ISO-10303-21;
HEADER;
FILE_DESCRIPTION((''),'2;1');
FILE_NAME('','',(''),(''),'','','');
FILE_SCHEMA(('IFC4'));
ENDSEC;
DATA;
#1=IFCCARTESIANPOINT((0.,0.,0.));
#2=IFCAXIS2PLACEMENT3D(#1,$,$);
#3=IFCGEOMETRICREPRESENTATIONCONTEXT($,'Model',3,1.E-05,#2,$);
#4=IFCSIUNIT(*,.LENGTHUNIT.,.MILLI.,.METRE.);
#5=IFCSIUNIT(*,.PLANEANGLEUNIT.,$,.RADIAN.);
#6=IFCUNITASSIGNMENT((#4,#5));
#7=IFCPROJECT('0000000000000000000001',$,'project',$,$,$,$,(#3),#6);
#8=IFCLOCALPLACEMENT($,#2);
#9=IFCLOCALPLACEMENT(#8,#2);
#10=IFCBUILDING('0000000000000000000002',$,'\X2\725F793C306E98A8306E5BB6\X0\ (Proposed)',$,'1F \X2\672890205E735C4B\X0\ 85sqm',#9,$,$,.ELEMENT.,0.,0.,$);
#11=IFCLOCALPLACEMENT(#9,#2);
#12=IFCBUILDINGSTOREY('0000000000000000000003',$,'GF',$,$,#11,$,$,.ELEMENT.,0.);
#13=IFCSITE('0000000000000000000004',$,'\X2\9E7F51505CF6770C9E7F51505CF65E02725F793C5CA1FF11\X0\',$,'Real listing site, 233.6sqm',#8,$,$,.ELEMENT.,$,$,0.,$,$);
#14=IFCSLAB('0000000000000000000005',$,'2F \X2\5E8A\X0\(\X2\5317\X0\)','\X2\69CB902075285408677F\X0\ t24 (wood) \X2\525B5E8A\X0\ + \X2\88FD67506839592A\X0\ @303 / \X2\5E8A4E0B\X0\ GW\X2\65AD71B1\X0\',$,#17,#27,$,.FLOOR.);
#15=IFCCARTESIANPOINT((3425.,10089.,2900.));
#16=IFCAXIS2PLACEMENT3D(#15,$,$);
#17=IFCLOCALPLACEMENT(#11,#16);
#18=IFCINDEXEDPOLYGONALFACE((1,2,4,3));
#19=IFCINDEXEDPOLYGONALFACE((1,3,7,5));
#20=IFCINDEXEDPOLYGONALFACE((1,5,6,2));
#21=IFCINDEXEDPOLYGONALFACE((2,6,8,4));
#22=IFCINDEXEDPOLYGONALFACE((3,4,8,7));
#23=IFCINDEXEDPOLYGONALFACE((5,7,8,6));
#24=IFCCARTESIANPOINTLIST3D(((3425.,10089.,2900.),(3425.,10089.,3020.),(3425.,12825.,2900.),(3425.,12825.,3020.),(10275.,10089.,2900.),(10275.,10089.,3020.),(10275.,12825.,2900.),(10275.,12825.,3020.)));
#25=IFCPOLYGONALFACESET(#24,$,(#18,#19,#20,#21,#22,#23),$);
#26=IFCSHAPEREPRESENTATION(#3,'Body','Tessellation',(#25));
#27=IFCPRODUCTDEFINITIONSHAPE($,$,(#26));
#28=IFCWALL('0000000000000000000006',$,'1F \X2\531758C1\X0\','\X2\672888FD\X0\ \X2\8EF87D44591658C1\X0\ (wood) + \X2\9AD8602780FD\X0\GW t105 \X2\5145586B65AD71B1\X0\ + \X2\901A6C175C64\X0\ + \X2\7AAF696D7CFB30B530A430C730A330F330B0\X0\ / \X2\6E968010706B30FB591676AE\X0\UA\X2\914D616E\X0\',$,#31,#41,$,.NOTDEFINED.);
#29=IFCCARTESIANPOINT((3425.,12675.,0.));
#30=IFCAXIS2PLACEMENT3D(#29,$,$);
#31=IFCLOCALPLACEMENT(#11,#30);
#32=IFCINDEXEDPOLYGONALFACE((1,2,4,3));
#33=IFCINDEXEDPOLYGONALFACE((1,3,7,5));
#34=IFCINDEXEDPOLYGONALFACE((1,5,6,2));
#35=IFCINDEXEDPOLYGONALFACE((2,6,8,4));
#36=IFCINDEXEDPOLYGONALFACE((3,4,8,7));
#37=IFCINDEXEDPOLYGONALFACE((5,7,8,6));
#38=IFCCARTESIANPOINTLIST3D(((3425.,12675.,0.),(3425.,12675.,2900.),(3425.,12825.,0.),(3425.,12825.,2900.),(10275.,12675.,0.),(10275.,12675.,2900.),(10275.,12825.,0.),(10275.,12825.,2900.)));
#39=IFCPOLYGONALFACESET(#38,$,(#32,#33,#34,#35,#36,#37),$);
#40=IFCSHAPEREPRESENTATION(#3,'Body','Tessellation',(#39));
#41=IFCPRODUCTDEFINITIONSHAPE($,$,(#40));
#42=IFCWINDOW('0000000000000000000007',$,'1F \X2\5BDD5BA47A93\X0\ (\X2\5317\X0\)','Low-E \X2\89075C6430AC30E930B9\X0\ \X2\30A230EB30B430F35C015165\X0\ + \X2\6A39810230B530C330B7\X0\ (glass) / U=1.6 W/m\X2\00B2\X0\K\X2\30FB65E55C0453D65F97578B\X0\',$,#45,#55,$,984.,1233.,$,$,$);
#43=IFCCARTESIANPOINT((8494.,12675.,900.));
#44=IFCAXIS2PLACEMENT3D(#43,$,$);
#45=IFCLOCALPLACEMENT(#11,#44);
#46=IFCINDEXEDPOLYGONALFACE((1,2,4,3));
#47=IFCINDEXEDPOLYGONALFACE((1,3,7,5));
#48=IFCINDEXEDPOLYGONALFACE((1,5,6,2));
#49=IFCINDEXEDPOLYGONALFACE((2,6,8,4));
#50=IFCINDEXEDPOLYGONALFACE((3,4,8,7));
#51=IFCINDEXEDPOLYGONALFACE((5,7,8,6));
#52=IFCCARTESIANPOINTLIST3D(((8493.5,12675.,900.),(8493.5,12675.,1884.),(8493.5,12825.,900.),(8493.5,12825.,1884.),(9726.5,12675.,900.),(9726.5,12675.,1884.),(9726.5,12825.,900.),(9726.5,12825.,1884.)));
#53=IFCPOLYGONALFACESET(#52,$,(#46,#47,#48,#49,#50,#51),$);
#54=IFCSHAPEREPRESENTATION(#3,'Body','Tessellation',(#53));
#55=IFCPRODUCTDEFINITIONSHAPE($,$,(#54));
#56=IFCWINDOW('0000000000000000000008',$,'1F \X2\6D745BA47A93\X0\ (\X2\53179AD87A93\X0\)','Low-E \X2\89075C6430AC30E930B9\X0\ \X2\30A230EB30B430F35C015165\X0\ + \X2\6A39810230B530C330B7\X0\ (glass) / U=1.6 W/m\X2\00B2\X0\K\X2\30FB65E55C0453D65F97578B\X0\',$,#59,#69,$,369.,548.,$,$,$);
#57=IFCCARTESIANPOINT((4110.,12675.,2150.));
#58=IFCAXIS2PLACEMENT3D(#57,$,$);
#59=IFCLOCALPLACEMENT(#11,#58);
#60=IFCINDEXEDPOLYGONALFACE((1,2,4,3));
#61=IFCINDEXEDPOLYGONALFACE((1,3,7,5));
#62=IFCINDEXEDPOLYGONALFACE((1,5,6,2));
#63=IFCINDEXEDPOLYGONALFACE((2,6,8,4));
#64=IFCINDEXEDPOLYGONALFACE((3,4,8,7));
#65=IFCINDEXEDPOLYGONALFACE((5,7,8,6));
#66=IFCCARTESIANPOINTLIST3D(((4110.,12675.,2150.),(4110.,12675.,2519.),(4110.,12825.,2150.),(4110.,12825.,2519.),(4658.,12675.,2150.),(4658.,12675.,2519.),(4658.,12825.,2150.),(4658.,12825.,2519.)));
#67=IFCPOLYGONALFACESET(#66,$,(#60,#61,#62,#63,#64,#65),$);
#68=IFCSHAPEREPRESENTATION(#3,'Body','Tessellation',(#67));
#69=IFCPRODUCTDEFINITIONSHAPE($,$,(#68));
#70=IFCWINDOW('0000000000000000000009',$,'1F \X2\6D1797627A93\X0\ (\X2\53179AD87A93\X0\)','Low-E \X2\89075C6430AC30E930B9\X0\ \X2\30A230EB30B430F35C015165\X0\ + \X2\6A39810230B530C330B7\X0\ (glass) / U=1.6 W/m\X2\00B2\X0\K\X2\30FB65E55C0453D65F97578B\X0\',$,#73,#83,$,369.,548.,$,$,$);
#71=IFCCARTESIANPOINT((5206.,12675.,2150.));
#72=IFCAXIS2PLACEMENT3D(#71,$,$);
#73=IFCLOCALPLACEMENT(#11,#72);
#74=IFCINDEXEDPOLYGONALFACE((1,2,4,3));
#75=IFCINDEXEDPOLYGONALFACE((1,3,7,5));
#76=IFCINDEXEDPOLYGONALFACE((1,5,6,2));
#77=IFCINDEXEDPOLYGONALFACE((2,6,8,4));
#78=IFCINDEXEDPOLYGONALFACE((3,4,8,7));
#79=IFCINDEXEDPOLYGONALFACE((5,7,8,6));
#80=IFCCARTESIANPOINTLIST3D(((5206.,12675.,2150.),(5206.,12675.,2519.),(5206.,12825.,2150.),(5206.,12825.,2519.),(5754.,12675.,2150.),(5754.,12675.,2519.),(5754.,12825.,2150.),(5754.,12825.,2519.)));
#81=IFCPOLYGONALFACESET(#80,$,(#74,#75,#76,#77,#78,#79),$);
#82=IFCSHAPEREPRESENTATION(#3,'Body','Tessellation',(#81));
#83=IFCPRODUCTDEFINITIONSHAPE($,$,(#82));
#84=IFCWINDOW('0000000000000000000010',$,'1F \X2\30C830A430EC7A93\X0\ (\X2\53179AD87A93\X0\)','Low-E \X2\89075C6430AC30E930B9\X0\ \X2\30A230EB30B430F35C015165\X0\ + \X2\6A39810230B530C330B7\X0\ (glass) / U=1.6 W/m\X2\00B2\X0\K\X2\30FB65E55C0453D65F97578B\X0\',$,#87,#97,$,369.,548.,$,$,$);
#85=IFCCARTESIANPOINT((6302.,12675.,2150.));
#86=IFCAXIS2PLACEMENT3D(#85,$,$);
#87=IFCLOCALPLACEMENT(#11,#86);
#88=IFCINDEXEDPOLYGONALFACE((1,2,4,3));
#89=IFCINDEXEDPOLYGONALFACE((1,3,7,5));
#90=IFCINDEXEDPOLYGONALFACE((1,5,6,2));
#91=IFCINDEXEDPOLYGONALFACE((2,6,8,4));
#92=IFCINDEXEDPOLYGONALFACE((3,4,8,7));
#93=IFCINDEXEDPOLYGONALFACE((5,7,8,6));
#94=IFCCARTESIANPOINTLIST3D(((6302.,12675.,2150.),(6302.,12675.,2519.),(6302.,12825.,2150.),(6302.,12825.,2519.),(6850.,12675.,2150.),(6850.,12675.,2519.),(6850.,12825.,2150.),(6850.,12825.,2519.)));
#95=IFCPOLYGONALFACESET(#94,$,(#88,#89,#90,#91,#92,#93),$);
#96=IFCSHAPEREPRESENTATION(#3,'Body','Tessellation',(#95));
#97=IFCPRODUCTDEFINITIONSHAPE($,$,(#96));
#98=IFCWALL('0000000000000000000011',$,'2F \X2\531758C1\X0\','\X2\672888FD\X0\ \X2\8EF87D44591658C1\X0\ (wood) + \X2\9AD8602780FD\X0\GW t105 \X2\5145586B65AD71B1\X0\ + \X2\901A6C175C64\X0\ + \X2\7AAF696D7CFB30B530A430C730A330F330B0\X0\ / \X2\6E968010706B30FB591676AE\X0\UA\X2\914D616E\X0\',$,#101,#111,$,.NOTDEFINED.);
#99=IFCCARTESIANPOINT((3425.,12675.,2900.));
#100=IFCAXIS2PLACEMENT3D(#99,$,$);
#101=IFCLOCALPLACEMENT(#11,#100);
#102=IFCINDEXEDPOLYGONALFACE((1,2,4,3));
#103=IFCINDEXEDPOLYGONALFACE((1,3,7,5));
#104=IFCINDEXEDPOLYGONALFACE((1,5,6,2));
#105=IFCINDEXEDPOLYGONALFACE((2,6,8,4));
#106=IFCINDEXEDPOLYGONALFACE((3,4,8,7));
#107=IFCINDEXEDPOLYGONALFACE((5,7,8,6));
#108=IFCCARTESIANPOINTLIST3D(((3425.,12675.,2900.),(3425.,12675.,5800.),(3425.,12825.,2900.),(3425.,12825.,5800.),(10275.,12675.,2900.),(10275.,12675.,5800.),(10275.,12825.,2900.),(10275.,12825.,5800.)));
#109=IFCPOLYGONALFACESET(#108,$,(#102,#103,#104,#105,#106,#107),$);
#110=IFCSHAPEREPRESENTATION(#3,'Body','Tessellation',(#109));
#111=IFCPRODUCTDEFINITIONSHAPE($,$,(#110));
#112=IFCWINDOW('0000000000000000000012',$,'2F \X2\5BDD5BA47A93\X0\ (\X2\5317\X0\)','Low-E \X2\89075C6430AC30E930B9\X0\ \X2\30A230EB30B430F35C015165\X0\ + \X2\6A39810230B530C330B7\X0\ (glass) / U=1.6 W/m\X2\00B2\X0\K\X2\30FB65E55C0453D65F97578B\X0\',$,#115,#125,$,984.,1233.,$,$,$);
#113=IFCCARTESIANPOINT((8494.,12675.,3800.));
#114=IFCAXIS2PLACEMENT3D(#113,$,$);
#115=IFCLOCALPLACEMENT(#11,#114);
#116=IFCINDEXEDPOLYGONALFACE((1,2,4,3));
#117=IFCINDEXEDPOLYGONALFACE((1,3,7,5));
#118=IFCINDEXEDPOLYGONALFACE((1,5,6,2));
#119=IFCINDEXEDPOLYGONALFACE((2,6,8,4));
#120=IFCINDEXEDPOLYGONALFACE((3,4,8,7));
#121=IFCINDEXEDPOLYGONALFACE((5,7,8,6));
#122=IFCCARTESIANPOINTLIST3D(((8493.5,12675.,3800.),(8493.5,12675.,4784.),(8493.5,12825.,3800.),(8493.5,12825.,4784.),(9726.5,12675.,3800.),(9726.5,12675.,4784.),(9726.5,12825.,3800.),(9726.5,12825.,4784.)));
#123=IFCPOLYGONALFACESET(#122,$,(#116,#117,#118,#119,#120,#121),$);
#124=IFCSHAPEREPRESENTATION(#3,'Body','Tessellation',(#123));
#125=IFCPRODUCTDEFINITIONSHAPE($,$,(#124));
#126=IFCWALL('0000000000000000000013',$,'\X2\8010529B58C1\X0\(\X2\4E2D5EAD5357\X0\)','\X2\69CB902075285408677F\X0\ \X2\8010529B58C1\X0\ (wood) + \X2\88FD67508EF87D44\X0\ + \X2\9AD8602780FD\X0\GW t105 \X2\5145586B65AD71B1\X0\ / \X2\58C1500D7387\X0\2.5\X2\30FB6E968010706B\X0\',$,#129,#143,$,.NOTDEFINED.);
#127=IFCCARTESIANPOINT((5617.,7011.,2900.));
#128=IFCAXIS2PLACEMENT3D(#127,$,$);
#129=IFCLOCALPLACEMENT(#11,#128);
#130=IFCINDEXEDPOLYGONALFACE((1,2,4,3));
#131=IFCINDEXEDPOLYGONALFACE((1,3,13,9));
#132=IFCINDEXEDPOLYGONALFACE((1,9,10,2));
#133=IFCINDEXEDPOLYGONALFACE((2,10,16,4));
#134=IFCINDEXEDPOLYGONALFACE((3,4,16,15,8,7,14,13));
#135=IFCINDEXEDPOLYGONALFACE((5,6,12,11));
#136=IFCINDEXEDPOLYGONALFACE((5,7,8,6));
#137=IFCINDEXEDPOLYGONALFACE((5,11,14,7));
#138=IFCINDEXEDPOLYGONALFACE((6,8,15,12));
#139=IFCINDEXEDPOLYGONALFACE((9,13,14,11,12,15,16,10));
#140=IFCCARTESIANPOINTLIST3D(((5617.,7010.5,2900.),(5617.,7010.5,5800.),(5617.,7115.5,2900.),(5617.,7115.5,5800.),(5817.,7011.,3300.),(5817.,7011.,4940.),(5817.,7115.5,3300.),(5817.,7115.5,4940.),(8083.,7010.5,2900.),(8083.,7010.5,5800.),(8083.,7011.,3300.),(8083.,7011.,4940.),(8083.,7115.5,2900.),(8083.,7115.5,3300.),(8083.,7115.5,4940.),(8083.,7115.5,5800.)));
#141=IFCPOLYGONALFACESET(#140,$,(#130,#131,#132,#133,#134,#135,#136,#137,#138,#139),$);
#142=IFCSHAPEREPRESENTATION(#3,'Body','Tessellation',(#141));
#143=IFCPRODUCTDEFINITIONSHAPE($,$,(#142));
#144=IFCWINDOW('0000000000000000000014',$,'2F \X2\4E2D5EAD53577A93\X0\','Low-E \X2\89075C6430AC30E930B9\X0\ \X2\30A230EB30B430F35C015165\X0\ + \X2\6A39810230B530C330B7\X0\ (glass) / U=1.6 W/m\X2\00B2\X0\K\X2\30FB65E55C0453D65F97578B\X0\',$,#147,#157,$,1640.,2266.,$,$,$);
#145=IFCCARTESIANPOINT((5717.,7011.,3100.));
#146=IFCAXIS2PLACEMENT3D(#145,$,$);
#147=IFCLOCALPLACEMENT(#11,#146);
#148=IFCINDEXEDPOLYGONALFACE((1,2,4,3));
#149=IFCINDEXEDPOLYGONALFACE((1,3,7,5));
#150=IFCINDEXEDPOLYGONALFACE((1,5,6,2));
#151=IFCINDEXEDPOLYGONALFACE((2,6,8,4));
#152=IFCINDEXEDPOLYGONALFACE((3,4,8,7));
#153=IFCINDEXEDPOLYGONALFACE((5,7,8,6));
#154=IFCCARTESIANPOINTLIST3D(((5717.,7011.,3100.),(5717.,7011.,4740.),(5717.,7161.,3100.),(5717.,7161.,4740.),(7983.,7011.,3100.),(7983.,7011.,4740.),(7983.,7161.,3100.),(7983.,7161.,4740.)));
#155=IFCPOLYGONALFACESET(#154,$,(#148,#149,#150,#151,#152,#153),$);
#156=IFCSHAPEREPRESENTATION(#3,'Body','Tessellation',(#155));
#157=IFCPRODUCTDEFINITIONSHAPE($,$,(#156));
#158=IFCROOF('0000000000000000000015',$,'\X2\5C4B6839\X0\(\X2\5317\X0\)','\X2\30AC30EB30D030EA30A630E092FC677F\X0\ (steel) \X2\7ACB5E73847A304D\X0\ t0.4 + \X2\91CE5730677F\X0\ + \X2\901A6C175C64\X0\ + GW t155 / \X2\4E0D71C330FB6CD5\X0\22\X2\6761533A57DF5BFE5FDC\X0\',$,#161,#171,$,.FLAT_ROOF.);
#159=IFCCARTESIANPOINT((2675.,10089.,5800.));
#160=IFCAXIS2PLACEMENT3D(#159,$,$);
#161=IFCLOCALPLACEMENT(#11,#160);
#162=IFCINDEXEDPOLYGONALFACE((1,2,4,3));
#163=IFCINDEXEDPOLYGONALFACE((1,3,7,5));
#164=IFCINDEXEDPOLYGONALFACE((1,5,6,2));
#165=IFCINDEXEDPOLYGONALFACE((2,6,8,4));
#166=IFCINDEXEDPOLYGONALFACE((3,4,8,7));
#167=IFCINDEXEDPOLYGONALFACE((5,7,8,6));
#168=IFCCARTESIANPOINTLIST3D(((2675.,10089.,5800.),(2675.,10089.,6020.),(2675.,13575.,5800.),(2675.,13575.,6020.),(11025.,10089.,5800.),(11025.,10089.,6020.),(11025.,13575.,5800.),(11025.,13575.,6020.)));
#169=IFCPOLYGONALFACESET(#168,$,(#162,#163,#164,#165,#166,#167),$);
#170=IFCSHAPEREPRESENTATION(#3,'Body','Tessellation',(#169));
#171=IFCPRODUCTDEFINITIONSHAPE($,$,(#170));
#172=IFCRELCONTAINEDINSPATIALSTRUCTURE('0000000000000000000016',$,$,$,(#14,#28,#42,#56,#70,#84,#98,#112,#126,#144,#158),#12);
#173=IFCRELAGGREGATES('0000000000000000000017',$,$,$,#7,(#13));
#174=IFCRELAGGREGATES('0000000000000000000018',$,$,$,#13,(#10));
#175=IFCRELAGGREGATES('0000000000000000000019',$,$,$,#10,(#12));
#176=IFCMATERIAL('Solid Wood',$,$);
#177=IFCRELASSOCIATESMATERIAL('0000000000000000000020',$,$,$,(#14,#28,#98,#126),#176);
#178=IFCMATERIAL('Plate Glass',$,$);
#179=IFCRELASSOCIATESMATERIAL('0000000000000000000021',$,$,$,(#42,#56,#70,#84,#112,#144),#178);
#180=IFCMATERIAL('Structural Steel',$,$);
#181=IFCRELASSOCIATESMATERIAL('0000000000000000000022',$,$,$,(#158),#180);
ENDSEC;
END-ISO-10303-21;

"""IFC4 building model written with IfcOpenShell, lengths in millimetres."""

from ifc_helpers import new_model, si_unit, frame, frame_2d, origin, place, context, project, spatial, rectangle, extrude, material, element, fill, save


model = new_model("IFC4")

# Units and contexts
model_context = context("Model", 3, precision=1e-05, world=origin())
ifc_project = project(units=[si_unit("LENGTHUNIT", "METRE", prefix="MILLI"), si_unit("PLANEANGLEUNIT", "RADIAN")], contexts=[model_context])

# Site, building, storey
site_placement = place(None, origin())
site = spatial("IfcSite", under=ifc_project, at=site_placement, Name="鹿児島県鹿児島市牟礼岡１", ObjectType="Real listing site, 233.6sqm", CompositionType="ELEMENT", RefElevation=0.0)
building_placement = place(site_placement, origin())
building = spatial("IfcBuilding", under=site, at=building_placement, Name="牟礼の風の家 (Proposed)", ObjectType="1F 木造平屋 85sqm", CompositionType="ELEMENT", ElevationOfRefHeight=0.0, ElevationOfTerrain=0.0)
storey_placement = place(building_placement, origin())
storey = spatial("IfcBuildingStorey", under=building, at=storey_placement, Name="GF", CompositionType="ELEMENT", Elevation=0.0)

# Slab
ifc_material_1 = material(Name="Solid Wood")
slab_1_placement = place(storey_placement, frame((3425.0, 10089.0, 2900.0)))
element("IfcSlab", 1, at=slab_1_placement, inside=storey, material=ifc_material_1, Name="2F 床(北)", Description="構造用合板 t24 (wood) 剛床 + 製材根太 @303 / 床下 GW断熱", PredefinedType="FLOOR", context=model_context, shape_type="SweptSolid", body=[
    extrude(rectangle(XDim=6850.0, YDim=2736.0, at=frame_2d((3425.0, 1368.0))), frame((3425.0, 10089.0, 2900.0)), (0.0, 0.0, 1.0), 120.0),
])

# Wall, openings, windows
wall_1_placement = place(storey_placement, frame((3425.0, 12675.0, 0.0)))
wall_1 = element("IfcWall", 2, at=wall_1_placement, inside=storey, material=ifc_material_1, Name="1F 北壁", Description="木製 軸組外壁 (wood) + 高性能GW t105 充填断熱 + 通気層 + 窯業系サイディング / 準耐火・外皮UA配慮", PredefinedType="NOTDEFINED", context=model_context, shape_type="SweptSolid", body=[
    extrude(rectangle(XDim=6850.0, YDim=150.0, at=frame_2d((3425.0, 75.0))), frame((3425.0, 12675.0, 0.0)), (0.0, 0.0, 1.0), 2900.0),
])
opening_1_placement = place(storey_placement, frame((8494.0, 12675.0, 900.0)))
opening_1 = element("IfcOpeningElement", 3, at=opening_1_placement, cuts=wall_1, PredefinedType="NOTDEFINED", context=model_context, shape_type="SweptSolid", body=[
    extrude(rectangle(XDim=1233.0, YDim=150.0, at=frame_2d((616.0, 75.0))), frame((8494.0, 12675.0, 900.0)), (0.0, 0.0, 1.0), 984.0),
])
opening_2_placement = place(storey_placement, frame((4110.0, 12675.0, 2150.0)))
opening_2 = element("IfcOpeningElement", 4, at=opening_2_placement, cuts=wall_1, PredefinedType="NOTDEFINED", context=model_context, shape_type="SweptSolid", body=[
    extrude(rectangle(XDim=548.0, YDim=150.0, at=frame_2d((274.0, 75.0))), frame((4110.0, 12675.0, 2150.0)), (0.0, 0.0, 1.0), 369.0),
])
opening_3_placement = place(storey_placement, frame((5206.0, 12675.0, 2150.0)))
opening_3 = element("IfcOpeningElement", 5, at=opening_3_placement, cuts=wall_1, PredefinedType="NOTDEFINED", context=model_context, shape_type="SweptSolid", body=[
    extrude(rectangle(XDim=548.0, YDim=150.0, at=frame_2d((274.0, 75.0))), frame((5206.0, 12675.0, 2150.0)), (0.0, 0.0, 1.0), 369.0),
])
opening_4_placement = place(storey_placement, frame((6302.0, 12675.0, 2150.0)))
opening_4 = element("IfcOpeningElement", 6, at=opening_4_placement, cuts=wall_1, PredefinedType="NOTDEFINED", context=model_context, shape_type="SweptSolid", body=[
    extrude(rectangle(XDim=548.0, YDim=150.0, at=frame_2d((274.0, 75.0))), frame((6302.0, 12675.0, 2150.0)), (0.0, 0.0, 1.0), 369.0),
])
ifc_material_2 = material(Name="Plate Glass")
window_1_placement = place(storey_placement, frame((8494.0, 12675.0, 900.0)))
window_1 = element("IfcWindow", 7, at=window_1_placement, inside=storey, material=ifc_material_2, Name="1F 寝室窓 (北)", Description="Low-E 複層ガラス アルゴン封入 + 樹脂サッシ (glass) / U=1.6 W/m²K・日射取得型", OverallHeight=984.0, OverallWidth=1233.0, context=model_context, shape_type="SweptSolid", body=[
    extrude(rectangle(XDim=1233.0, YDim=150.0, at=frame_2d((616.0, 75.0))), frame((8494.0, 12675.0, 900.0)), (0.0, 0.0, 1.0), 984.0),
])
fill(opening_1, window_1)
window_2_placement = place(storey_placement, frame((4110.0, 12675.0, 2150.0)))
window_2 = element("IfcWindow", 8, at=window_2_placement, inside=storey, material=ifc_material_2, Name="1F 浴室窓 (北高窓)", Description="Low-E 複層ガラス アルゴン封入 + 樹脂サッシ (glass) / U=1.6 W/m²K・日射取得型", OverallHeight=369.0, OverallWidth=548.0, context=model_context, shape_type="SweptSolid", body=[
    extrude(rectangle(XDim=548.0, YDim=150.0, at=frame_2d((274.0, 75.0))), frame((4110.0, 12675.0, 2150.0)), (0.0, 0.0, 1.0), 369.0),
])
fill(opening_2, window_2)
window_3_placement = place(storey_placement, frame((5206.0, 12675.0, 2150.0)))
window_3 = element("IfcWindow", 9, at=window_3_placement, inside=storey, material=ifc_material_2, Name="1F 洗面窓 (北高窓)", Description="Low-E 複層ガラス アルゴン封入 + 樹脂サッシ (glass) / U=1.6 W/m²K・日射取得型", OverallHeight=369.0, OverallWidth=548.0, context=model_context, shape_type="SweptSolid", body=[
    extrude(rectangle(XDim=548.0, YDim=150.0, at=frame_2d((274.0, 75.0))), frame((5206.0, 12675.0, 2150.0)), (0.0, 0.0, 1.0), 369.0),
])
fill(opening_3, window_3)
window_4_placement = place(storey_placement, frame((6302.0, 12675.0, 2150.0)))
window_4 = element("IfcWindow", 10, at=window_4_placement, inside=storey, material=ifc_material_2, Name="1F トイレ窓 (北高窓)", Description="Low-E 複層ガラス アルゴン封入 + 樹脂サッシ (glass) / U=1.6 W/m²K・日射取得型", OverallHeight=369.0, OverallWidth=548.0, context=model_context, shape_type="SweptSolid", body=[
    extrude(rectangle(XDim=548.0, YDim=150.0, at=frame_2d((274.0, 75.0))), frame((6302.0, 12675.0, 2150.0)), (0.0, 0.0, 1.0), 369.0),
])
fill(opening_4, window_4)

# Walls, openings, windows
wall_2_placement = place(storey_placement, frame((3425.0, 12675.0, 2900.0)))
wall_2 = element("IfcWall", 11, at=wall_2_placement, inside=storey, material=ifc_material_1, Name="2F 北壁", Description="木製 軸組外壁 (wood) + 高性能GW t105 充填断熱 + 通気層 + 窯業系サイディング / 準耐火・外皮UA配慮", PredefinedType="NOTDEFINED", context=model_context, shape_type="SweptSolid", body=[
    extrude(rectangle(XDim=6850.0, YDim=150.0, at=frame_2d((3425.0, 75.0))), frame((3425.0, 12675.0, 2900.0)), (0.0, 0.0, 1.0), 2900.0),
])
opening_5_placement = place(storey_placement, frame((8494.0, 12675.0, 3800.0)))
opening_5 = element("IfcOpeningElement", 12, at=opening_5_placement, cuts=wall_2, PredefinedType="NOTDEFINED", context=model_context, shape_type="SweptSolid", body=[
    extrude(rectangle(XDim=1233.0, YDim=150.0, at=frame_2d((616.0, 75.0))), frame((8494.0, 12675.0, 3800.0)), (0.0, 0.0, 1.0), 984.0),
])
window_5_placement = place(storey_placement, frame((8494.0, 12675.0, 3800.0)))
window_5 = element("IfcWindow", 13, at=window_5_placement, inside=storey, material=ifc_material_2, Name="2F 寝室窓 (北)", Description="Low-E 複層ガラス アルゴン封入 + 樹脂サッシ (glass) / U=1.6 W/m²K・日射取得型", OverallHeight=984.0, OverallWidth=1233.0, context=model_context, shape_type="SweptSolid", body=[
    extrude(rectangle(XDim=1233.0, YDim=150.0, at=frame_2d((616.0, 75.0))), frame((8494.0, 12675.0, 3800.0)), (0.0, 0.0, 1.0), 984.0),
])
fill(opening_5, window_5)
wall_3_placement = place(storey_placement, frame((5617.0, 7011.0, 2900.0)))
wall_3 = element("IfcWall", 14, at=wall_3_placement, inside=storey, material=ifc_material_1, Name="耐力壁(中庭南)", Description="構造用合板 耐力壁 (wood) + 製材軸組 + 高性能GW t105 充填断熱 / 壁倍率2.5・準耐火", PredefinedType="NOTDEFINED", context=model_context, shape_type="SweptSolid", body=[
    extrude(rectangle(XDim=2466.0, YDim=105.0, at=frame_2d((1233.0, 52.0))), frame((5617.0, 7011.0, 2900.0)), (0.0, 0.0, 1.0), 2900.0),
])
opening_6_placement = place(storey_placement, frame((5717.0, 7011.0, 3100.0)))
opening_6 = element("IfcOpeningElement", 15, at=opening_6_placement, cuts=wall_3, PredefinedType="NOTDEFINED", context=model_context, shape_type="SweptSolid", body=[
    extrude(rectangle(XDim=2266.0, YDim=150.0, at=frame_2d((1133.0, 75.0))), frame((5717.0, 7011.0, 3100.0)), (0.0, 0.0, 1.0), 1640.0),
])
window_6_placement = place(storey_placement, frame((5717.0, 7011.0, 3100.0)))
window_6 = element("IfcWindow", 16, at=window_6_placement, inside=storey, material=ifc_material_2, Name="2F 中庭南窓", Description="Low-E 複層ガラス アルゴン封入 + 樹脂サッシ (glass) / U=1.6 W/m²K・日射取得型", OverallHeight=1640.0, OverallWidth=2266.0, context=model_context, shape_type="SweptSolid", body=[
    extrude(rectangle(XDim=2266.0, YDim=150.0, at=frame_2d((1133.0, 75.0))), frame((5717.0, 7011.0, 3100.0)), (0.0, 0.0, 1.0), 1640.0),
])
fill(opening_6, window_6)

# Roof
ifc_material_3 = material(Name="Structural Steel")
for number, where, name in (
    (17, (2675.0, 10089.0, 5800.0), "屋根(北)"),
):
    element("IfcRoof", number, at=place(storey_placement, frame(where)), inside=storey, material=ifc_material_3, Name=name, Description="ガルバリウム鋼板 (steel) 立平葺き t0.4 + 野地板 + 通気層 + GW t155 / 不燃・法22条区域対応", PredefinedType="FLAT_ROOF", context=model_context, shape_type="SweptSolid", body=[
        extrude(rectangle(XDim=8350.0, YDim=3486.0, at=frame_2d((4175.0, 1743.0))), frame((2675.0, 10089.0, 5800.0)), (0.0, 0.0, 1.0), 220.0),
    ])

save(model, "model.ifc")
